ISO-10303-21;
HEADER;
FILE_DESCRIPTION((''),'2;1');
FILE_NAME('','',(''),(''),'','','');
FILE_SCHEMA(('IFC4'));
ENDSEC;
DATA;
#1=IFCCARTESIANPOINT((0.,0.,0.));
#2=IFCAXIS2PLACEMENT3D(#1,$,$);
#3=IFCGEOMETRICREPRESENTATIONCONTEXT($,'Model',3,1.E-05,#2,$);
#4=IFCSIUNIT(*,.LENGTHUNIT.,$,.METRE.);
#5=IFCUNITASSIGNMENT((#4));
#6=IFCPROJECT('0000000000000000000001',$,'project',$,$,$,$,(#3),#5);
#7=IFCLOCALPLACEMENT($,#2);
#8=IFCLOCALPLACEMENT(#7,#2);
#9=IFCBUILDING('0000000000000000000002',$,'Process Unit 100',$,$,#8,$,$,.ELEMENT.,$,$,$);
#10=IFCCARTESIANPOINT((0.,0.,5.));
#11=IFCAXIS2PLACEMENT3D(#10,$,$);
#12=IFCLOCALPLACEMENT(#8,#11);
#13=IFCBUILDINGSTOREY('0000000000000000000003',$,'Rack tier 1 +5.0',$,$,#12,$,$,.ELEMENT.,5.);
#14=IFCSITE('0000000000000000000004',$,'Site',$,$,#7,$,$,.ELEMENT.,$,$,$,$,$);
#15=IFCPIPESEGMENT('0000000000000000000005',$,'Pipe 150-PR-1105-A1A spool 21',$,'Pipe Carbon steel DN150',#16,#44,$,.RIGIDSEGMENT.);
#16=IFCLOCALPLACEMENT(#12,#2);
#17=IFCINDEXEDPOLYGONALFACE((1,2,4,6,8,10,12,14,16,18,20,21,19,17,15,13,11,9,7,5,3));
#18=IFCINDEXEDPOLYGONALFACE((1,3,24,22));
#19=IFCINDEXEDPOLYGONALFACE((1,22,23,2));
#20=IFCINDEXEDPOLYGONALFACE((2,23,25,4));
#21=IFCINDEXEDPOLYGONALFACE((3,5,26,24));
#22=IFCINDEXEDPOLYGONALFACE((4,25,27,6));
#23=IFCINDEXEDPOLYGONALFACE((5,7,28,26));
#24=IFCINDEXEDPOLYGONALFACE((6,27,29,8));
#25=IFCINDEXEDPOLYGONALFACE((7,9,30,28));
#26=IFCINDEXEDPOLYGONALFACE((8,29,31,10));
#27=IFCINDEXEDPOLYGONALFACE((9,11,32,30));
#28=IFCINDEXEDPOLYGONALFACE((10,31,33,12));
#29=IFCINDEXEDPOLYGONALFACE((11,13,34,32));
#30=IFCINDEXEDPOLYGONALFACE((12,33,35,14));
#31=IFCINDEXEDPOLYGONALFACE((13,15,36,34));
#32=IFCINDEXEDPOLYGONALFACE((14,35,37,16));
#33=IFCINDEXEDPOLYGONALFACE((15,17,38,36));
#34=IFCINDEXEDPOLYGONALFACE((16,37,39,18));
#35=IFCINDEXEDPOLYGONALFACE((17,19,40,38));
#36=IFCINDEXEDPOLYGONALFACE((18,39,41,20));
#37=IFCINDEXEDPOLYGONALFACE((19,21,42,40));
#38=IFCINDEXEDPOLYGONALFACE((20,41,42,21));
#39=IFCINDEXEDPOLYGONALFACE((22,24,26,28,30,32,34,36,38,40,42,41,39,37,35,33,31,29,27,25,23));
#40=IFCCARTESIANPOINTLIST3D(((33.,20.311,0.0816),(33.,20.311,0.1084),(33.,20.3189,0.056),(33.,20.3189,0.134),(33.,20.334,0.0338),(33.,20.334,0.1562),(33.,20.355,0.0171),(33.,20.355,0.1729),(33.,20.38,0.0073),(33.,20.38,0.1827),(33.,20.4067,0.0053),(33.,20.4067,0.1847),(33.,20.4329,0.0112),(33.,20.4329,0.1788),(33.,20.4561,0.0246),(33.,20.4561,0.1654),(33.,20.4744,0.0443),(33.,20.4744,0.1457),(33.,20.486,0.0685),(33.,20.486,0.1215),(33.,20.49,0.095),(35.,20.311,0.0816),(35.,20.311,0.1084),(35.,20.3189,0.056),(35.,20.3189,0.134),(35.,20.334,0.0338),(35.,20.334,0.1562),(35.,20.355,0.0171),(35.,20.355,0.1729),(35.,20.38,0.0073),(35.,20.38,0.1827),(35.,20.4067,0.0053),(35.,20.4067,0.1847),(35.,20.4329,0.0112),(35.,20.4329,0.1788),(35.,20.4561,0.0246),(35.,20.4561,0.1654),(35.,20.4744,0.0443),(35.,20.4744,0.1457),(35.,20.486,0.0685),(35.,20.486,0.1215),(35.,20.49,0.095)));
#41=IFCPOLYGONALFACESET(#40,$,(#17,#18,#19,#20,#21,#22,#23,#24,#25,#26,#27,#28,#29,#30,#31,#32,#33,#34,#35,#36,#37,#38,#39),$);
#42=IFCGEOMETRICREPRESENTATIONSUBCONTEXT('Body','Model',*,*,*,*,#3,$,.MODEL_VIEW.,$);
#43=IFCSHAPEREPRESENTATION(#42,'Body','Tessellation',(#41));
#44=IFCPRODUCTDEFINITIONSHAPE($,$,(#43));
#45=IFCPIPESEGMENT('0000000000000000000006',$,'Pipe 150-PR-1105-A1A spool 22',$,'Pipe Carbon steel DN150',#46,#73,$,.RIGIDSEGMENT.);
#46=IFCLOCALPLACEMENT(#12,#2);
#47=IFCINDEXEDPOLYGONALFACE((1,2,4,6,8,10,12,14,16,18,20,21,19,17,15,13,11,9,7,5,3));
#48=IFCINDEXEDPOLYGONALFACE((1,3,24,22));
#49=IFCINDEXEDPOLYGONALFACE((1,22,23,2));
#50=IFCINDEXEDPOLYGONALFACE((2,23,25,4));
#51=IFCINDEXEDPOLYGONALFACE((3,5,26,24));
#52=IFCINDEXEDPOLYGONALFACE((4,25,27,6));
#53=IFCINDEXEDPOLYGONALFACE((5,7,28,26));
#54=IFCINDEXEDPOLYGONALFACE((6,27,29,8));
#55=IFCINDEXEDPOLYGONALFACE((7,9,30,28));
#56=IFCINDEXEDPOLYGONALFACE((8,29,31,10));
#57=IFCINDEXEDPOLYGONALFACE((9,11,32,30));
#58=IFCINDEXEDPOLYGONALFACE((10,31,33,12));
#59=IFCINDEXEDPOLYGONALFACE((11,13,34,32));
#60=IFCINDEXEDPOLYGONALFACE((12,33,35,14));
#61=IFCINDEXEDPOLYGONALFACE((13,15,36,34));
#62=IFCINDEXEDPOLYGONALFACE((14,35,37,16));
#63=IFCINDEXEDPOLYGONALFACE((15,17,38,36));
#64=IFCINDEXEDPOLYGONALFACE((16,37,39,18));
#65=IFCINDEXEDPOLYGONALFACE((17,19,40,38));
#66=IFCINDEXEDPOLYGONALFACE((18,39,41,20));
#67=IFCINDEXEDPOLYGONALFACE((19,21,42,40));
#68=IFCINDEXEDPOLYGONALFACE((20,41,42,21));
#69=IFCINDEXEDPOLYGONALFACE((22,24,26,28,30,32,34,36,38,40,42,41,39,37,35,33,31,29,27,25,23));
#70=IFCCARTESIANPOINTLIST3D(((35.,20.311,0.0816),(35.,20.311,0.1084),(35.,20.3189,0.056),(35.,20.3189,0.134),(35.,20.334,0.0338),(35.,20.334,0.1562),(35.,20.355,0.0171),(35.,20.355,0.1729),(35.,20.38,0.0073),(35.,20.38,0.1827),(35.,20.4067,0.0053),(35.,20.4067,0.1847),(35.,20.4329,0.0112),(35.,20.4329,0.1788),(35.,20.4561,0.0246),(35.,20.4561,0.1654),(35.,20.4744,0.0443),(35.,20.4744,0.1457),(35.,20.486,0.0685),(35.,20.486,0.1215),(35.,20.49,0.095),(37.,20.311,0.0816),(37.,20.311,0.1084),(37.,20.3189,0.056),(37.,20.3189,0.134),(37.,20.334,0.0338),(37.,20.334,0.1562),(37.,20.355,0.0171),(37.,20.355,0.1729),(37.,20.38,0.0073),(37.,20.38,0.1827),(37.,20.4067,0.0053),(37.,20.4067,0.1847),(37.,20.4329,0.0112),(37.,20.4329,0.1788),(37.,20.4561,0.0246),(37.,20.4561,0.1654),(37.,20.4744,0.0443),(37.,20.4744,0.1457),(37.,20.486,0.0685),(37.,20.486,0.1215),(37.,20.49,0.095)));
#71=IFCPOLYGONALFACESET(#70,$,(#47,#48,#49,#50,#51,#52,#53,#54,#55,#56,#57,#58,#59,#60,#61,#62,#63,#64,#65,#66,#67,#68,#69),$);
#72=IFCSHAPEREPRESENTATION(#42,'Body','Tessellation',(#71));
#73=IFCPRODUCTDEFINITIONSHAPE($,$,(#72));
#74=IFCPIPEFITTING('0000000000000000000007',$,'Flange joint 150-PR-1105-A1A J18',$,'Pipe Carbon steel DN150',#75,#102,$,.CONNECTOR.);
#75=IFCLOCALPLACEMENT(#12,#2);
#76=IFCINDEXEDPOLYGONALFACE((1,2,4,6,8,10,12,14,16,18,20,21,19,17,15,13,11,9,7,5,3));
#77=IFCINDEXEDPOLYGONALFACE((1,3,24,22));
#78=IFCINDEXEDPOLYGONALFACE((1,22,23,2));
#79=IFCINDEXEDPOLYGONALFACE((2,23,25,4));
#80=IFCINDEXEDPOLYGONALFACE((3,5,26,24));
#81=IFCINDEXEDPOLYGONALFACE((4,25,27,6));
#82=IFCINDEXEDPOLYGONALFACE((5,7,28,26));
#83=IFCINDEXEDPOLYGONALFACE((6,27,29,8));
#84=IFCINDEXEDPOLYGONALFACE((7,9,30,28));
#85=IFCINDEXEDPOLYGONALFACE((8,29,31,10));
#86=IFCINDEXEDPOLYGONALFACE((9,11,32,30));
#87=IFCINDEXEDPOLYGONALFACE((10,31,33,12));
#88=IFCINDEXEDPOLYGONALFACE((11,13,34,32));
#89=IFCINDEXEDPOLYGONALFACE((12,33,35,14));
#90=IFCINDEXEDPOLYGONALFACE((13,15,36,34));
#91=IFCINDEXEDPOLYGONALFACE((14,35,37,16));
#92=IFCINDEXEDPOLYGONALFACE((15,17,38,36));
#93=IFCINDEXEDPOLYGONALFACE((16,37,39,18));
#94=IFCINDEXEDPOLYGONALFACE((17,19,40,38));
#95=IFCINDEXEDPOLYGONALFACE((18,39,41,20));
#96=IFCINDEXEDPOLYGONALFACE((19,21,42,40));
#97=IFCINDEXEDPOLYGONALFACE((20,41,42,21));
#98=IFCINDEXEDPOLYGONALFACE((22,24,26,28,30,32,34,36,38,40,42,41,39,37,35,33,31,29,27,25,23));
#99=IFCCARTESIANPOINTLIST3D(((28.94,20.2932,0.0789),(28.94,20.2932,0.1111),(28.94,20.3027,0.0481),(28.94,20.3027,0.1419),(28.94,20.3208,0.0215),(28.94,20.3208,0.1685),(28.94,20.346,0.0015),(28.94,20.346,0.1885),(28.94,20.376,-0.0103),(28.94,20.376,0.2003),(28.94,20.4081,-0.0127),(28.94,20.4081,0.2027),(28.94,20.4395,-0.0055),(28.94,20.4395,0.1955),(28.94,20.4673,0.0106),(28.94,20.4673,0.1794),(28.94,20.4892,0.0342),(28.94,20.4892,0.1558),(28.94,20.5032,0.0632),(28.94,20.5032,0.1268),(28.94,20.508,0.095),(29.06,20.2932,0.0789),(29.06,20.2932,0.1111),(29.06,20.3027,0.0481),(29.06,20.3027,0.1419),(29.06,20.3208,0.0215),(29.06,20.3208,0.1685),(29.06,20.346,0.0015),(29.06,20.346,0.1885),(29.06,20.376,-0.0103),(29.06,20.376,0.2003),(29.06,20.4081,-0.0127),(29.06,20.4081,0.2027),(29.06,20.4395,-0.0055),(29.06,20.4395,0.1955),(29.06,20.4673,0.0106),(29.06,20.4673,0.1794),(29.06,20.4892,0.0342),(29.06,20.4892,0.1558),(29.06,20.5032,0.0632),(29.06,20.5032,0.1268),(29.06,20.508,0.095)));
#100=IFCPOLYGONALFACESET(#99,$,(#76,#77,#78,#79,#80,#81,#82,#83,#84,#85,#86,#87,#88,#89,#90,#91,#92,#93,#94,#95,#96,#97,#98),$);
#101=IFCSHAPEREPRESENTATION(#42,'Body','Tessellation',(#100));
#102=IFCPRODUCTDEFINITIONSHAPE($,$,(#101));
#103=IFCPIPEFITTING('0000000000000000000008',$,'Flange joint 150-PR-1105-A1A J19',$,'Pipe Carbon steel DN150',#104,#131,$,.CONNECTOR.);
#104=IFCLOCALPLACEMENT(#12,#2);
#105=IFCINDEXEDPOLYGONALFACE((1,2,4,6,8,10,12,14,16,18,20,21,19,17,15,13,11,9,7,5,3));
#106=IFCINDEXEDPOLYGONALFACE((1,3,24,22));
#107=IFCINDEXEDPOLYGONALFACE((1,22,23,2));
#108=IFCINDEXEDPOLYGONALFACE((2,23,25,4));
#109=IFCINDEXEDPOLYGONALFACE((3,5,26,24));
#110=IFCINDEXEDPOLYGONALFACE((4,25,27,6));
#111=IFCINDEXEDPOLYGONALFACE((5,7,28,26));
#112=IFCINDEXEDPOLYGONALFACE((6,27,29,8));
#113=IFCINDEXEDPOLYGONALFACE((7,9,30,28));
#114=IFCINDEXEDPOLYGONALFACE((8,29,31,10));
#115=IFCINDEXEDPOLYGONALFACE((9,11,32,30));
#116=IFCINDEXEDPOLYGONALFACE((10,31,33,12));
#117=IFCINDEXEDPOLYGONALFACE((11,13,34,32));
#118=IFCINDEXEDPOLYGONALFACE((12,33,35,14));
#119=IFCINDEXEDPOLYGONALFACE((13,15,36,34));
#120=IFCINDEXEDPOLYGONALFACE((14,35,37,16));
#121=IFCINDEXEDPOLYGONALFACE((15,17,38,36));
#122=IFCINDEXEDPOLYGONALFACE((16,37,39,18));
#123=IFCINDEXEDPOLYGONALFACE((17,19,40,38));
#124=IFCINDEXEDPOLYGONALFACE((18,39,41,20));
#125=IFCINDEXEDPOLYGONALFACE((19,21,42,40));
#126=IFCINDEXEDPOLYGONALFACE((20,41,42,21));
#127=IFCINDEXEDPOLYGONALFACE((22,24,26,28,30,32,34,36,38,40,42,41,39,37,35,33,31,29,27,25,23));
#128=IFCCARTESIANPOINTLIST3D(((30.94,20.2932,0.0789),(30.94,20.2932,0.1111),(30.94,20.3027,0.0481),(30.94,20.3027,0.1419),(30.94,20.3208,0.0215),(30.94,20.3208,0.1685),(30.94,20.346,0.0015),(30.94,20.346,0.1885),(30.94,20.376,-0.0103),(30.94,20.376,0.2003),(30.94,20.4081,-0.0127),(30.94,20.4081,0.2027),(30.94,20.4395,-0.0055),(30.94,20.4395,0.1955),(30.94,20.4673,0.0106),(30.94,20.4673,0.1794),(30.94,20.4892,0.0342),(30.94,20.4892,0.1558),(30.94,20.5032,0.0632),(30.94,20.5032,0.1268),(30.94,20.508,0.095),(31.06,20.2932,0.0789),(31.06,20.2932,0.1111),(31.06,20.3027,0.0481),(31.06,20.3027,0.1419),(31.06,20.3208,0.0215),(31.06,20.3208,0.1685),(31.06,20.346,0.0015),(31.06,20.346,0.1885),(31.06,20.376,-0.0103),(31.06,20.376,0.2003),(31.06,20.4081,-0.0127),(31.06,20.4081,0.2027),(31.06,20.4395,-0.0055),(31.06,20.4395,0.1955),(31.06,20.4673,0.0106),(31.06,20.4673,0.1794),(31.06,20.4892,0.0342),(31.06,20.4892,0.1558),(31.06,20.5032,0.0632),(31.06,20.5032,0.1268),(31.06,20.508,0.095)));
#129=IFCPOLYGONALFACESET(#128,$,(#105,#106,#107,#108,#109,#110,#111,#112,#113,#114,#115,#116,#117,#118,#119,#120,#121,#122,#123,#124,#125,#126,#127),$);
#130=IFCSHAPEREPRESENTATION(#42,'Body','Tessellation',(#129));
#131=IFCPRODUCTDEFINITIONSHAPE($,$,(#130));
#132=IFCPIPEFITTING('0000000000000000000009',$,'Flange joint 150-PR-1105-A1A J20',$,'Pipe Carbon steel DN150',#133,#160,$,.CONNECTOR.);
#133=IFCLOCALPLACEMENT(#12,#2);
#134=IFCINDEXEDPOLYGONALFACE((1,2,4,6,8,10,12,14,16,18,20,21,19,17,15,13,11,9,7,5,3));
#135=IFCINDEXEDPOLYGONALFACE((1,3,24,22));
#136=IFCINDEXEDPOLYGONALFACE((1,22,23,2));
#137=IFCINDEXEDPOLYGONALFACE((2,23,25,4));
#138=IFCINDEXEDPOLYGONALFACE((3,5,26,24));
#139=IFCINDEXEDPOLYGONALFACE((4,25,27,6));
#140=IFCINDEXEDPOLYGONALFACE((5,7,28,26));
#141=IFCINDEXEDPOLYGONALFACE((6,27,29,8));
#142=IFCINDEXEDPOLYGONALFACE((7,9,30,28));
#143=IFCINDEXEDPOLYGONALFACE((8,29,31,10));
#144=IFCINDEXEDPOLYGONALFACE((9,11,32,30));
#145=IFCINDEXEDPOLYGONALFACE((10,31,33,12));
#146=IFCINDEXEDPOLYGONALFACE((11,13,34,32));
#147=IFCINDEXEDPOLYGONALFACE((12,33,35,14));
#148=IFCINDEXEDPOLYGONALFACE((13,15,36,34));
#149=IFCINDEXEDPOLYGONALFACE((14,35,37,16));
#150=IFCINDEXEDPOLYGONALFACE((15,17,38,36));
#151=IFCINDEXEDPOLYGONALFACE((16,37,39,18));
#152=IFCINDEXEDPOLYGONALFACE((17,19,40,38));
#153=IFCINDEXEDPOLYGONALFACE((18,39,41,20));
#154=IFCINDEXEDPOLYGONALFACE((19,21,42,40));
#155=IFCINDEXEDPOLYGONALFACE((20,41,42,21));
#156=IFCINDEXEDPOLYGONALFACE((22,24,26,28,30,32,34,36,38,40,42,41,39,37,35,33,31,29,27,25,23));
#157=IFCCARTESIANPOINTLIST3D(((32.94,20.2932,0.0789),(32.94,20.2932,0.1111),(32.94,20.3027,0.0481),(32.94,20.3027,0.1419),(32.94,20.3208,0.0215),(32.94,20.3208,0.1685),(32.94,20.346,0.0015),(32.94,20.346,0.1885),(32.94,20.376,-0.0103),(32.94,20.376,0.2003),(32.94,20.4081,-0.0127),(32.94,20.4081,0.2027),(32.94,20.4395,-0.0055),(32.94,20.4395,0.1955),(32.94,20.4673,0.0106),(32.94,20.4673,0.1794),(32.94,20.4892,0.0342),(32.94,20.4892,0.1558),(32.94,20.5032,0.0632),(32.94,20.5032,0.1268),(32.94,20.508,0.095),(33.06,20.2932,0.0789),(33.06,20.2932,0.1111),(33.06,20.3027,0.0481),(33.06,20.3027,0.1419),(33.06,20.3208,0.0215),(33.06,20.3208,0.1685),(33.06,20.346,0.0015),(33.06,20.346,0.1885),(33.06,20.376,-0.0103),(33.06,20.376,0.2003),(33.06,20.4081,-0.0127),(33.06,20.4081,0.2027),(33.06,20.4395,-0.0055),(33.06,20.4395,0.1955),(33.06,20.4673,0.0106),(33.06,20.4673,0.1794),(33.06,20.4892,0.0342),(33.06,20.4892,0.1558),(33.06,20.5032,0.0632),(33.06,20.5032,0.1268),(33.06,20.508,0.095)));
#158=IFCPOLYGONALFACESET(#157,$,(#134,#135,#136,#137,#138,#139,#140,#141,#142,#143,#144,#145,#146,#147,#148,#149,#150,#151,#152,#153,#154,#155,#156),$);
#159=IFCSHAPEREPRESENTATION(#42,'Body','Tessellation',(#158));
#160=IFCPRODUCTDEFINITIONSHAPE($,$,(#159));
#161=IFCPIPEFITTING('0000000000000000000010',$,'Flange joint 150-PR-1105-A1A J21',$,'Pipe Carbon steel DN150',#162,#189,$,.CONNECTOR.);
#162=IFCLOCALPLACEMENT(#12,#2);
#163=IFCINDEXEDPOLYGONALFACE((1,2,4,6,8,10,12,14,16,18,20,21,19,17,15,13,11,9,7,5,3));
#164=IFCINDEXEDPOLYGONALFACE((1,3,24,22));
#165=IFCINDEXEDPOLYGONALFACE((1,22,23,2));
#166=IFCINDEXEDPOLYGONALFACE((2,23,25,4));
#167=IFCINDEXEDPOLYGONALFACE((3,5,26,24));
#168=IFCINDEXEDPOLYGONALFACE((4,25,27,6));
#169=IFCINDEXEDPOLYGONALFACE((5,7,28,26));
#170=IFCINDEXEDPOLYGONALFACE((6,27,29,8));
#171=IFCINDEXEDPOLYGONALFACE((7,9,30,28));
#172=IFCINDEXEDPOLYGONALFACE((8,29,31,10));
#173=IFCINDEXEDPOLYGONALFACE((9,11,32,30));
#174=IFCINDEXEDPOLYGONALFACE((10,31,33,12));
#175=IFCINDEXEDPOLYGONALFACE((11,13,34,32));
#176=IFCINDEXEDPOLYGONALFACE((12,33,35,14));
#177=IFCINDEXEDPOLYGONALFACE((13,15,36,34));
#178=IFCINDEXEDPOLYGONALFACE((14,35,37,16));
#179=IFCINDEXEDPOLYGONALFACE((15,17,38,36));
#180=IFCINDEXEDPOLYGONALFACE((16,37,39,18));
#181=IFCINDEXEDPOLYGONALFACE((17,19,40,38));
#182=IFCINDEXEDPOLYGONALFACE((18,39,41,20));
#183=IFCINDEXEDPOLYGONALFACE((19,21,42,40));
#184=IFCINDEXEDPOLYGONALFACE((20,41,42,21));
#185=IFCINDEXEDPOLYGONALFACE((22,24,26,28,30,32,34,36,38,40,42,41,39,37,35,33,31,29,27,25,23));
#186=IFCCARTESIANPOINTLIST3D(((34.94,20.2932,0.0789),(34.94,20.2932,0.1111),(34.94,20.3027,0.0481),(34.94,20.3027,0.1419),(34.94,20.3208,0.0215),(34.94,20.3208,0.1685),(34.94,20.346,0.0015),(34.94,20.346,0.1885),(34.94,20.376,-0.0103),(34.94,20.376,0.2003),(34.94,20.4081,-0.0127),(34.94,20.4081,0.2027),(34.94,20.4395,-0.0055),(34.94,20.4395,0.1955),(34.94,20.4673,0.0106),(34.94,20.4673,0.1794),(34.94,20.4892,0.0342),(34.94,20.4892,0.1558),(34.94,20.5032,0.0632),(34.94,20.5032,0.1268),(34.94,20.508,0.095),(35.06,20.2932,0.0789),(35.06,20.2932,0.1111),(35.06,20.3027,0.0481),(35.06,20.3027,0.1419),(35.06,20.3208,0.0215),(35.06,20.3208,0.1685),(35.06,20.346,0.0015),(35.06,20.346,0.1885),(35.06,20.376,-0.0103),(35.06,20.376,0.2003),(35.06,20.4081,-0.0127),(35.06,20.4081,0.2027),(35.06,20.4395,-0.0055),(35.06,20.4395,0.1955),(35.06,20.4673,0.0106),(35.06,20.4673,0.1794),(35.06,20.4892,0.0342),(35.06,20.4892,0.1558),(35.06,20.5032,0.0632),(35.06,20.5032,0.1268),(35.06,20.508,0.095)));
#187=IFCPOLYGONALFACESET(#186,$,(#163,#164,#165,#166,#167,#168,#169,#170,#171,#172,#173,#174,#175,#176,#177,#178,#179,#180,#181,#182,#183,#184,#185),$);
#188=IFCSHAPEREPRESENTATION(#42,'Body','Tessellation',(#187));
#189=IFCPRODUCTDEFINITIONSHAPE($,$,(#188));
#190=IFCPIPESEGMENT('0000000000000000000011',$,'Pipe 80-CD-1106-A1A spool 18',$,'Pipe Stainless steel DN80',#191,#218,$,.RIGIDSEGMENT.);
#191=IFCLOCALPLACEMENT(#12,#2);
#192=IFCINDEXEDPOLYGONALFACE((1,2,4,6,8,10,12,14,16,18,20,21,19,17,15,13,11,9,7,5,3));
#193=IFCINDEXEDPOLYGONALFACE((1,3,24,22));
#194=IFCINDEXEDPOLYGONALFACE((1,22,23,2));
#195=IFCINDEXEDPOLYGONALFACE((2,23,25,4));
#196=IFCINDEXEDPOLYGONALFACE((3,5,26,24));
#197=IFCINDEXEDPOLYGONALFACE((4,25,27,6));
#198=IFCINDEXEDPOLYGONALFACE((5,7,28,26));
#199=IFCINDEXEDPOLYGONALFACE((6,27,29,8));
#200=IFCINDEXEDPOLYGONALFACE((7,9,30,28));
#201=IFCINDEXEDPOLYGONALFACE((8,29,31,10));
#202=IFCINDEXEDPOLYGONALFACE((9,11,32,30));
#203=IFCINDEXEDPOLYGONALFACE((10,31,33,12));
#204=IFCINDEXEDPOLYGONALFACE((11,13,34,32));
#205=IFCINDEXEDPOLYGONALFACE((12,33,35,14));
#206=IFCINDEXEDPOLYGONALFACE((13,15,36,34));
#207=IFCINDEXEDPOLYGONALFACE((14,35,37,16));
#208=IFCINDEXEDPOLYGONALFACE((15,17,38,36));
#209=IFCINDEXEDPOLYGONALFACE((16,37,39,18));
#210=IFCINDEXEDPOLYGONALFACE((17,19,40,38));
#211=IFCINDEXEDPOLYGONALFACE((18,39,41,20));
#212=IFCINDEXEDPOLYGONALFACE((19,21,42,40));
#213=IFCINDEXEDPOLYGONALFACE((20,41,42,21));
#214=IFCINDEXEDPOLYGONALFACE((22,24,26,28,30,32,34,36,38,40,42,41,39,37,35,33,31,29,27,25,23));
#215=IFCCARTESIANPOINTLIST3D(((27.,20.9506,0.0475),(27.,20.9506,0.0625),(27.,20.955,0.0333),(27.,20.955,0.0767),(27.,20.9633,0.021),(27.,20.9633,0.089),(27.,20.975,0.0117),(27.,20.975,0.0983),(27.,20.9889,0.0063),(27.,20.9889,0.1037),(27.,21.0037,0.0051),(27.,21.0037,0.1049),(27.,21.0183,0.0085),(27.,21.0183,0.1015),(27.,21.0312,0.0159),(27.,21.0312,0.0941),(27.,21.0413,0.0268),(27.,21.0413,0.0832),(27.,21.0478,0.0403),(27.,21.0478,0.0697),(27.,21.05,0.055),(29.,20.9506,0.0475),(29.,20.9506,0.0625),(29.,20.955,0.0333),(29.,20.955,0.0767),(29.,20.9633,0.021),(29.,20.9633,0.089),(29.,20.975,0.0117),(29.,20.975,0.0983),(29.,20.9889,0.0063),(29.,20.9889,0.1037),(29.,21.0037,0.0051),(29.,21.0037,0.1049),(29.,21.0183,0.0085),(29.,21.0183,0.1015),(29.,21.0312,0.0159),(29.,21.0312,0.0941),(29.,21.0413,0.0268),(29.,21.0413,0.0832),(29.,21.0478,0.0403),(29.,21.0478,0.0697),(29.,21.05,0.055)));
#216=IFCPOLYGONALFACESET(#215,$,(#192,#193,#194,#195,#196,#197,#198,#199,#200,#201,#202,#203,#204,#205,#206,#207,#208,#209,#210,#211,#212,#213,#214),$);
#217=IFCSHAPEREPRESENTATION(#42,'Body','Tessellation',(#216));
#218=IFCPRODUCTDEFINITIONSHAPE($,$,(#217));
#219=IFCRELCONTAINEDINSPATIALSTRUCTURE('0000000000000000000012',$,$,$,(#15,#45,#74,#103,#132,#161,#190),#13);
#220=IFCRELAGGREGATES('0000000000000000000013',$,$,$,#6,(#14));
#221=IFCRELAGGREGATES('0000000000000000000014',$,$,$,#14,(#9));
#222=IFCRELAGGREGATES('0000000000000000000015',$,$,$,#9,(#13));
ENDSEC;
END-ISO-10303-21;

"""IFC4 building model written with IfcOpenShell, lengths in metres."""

from ifc_helpers import new_model, si_unit, frame, origin, place, context, subcontext, project, spatial, circle, extrude, element, save


model = new_model("IFC4")

# Units and contexts
model_context = context("Model", 3, precision=1e-05, world=origin())
body_context = subcontext(model_context, "Body", "Model", "MODEL_VIEW")
ifc_project = project(units=[si_unit("LENGTHUNIT", "METRE")], contexts=[model_context])

# Site, building, storey
site_placement = place(None, origin())
site = spatial("IfcSite", under=ifc_project, at=site_placement, Name="Site", CompositionType="ELEMENT")
building_placement = place(site_placement, origin())
building = spatial("IfcBuilding", under=site, at=building_placement, Name="Process Unit 100", CompositionType="ELEMENT")
storey_placement = place(building_placement, frame((0.0, 0.0, 5.0)))
storey = spatial("IfcBuildingStorey", under=building, at=storey_placement, Name="Rack tier 1 +5.0", CompositionType="ELEMENT", Elevation=5.0)

# Pipe segments
for number, where, z_axis, x_axis, name in (
    (1, (33.0, 20.4, 0.095), (1.0, 0.0, 0.0), (0.0, 1.0, 0.0), "Pipe 150-PR-1105-A1A spool 21"),
    (2, (35.0, 20.4, 0.095), (1.0, 0.0, 0.0), (0.0, 1.0, 0.0), "Pipe 150-PR-1105-A1A spool 22"),
):
    element("IfcPipeSegment", number, at=place(storey_placement, frame(where, z_axis=z_axis, x_axis=x_axis)), inside=storey, Name=name, ObjectType="Pipe Carbon steel DN150", PredefinedType="RIGIDSEGMENT", context=body_context, shape_type="SweptSolid", body=[
        extrude(circle(Radius=0.09), origin(), (0.0, 0.0, 1.0), 2.0),
    ])

# Pipe fittings
for number, where, z_axis, x_axis, name in (
    (3, (28.94, 20.4, 0.095), (1.0, 0.0, 0.0), (0.0, 1.0, 0.0), "Flange joint 150-PR-1105-A1A J18"),
    (4, (30.94, 20.4, 0.095), (1.0, 0.0, 0.0), (0.0, 1.0, 0.0), "Flange joint 150-PR-1105-A1A J19"),
    (5, (32.94, 20.4, 0.095), (1.0, 0.0, 0.0), (0.0, 1.0, 0.0), "Flange joint 150-PR-1105-A1A J20"),
    (6, (34.94, 20.4, 0.095), (1.0, 0.0, 0.0), (0.0, 1.0, 0.0), "Flange joint 150-PR-1105-A1A J21"),
):
    element("IfcPipeFitting", number, at=place(storey_placement, frame(where, z_axis=z_axis, x_axis=x_axis)), inside=storey, Name=name, ObjectType="Pipe Carbon steel DN150", PredefinedType="CONNECTOR", context=body_context, shape_type="SweptSolid", body=[
        extrude(circle(Radius=0.108), origin(), (0.0, 0.0, 1.0), 0.12),
    ])

# Pipe segment
for number, where, z_axis, x_axis, name in (
    (7, (27.0, 21.0, 0.055), (1.0, 0.0, 0.0), (0.0, 1.0, 0.0), "Pipe 80-CD-1106-A1A spool 18"),
):
    element("IfcPipeSegment", number, at=place(storey_placement, frame(where, z_axis=z_axis, x_axis=x_axis)), inside=storey, Name=name, ObjectType="Pipe Stainless steel DN80", PredefinedType="RIGIDSEGMENT", context=body_context, shape_type="SweptSolid", body=[
        extrude(circle(Radius=0.05), origin(), (0.0, 0.0, 1.0), 2.0),
    ])

save(model, "model.ifc")
